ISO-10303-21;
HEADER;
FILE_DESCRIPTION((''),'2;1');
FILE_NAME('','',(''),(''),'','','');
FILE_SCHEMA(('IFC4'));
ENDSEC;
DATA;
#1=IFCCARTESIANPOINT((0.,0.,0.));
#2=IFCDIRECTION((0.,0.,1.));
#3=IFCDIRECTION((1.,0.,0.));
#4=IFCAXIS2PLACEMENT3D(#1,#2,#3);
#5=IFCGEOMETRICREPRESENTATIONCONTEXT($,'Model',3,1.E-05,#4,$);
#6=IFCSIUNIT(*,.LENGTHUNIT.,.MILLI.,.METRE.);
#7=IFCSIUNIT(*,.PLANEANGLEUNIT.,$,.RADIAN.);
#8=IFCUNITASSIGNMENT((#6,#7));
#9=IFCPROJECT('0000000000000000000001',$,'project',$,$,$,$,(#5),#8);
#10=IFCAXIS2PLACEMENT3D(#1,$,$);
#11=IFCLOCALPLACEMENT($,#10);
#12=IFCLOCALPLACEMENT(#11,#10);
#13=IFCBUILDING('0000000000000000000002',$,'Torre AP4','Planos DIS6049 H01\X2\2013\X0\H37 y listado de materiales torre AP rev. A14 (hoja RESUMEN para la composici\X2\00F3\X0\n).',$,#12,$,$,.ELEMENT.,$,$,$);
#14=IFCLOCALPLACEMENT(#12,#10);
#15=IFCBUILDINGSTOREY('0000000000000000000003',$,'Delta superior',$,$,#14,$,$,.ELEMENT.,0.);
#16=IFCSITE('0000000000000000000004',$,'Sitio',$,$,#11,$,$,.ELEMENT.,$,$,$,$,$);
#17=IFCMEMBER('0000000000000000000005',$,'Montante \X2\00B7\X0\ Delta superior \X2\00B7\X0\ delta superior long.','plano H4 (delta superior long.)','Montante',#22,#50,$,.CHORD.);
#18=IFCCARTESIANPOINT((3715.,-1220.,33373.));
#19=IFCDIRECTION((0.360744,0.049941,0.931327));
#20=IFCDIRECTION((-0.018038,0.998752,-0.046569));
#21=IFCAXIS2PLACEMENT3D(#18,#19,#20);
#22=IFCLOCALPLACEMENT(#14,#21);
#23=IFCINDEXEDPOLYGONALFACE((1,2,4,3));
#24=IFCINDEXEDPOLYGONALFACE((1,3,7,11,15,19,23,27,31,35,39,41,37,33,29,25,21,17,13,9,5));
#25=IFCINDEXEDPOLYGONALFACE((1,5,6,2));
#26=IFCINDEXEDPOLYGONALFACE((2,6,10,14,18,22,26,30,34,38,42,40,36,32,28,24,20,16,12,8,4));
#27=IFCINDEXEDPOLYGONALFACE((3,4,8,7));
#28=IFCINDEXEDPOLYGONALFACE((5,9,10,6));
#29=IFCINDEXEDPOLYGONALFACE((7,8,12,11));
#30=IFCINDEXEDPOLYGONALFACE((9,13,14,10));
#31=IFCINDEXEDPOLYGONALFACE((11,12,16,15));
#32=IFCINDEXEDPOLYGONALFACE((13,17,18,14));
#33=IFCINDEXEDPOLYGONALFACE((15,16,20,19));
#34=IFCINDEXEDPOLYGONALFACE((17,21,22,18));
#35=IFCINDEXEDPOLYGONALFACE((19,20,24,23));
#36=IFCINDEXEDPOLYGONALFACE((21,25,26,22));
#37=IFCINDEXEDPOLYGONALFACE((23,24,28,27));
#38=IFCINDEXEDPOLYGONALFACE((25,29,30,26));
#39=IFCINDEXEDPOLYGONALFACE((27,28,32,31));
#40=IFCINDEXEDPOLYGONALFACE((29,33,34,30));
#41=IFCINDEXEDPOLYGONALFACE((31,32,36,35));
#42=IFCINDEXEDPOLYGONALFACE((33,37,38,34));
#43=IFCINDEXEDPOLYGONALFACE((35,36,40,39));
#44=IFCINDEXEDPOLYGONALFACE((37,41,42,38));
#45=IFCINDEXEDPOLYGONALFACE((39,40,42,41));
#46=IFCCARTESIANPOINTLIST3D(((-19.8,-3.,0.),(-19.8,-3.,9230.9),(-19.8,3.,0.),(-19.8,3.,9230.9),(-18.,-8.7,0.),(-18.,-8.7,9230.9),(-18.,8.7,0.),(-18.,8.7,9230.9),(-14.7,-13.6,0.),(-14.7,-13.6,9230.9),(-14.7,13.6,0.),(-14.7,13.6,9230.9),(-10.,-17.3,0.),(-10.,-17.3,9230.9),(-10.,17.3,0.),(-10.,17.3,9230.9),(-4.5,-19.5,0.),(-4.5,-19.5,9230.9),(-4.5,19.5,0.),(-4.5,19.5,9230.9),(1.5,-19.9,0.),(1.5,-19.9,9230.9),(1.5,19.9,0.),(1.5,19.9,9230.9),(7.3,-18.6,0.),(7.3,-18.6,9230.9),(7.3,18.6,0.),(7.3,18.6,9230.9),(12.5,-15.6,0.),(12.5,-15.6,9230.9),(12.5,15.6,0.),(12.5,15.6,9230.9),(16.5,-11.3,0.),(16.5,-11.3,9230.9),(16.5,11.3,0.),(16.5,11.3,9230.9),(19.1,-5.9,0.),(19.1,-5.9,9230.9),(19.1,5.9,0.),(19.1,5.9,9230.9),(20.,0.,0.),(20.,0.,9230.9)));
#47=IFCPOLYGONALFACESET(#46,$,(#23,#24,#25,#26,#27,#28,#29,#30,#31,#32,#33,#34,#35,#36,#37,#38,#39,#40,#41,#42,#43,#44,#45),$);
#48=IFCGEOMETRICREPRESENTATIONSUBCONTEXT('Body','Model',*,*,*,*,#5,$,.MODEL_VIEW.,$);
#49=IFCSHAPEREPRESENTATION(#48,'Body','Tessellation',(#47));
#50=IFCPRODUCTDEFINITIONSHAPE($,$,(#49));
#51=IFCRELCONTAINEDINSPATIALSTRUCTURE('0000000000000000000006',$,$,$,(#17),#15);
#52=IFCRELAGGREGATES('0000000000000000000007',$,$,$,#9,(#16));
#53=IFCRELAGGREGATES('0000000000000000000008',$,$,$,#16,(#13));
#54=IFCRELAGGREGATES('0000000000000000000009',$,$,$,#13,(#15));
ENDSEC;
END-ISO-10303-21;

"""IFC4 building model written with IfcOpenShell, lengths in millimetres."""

from ifc_helpers import new_model, si_unit, frame, origin, origin_with_axes, place, context, subcontext, project, spatial, circle, extrude, element, save


model = new_model("IFC4")

# Units and contexts
model_context = context("Model", 3, precision=1e-05, world=origin_with_axes())
body_context = subcontext(model_context, "Body", "Model", "MODEL_VIEW")
ifc_project = project(units=[si_unit("LENGTHUNIT", "METRE", prefix="MILLI"), si_unit("PLANEANGLEUNIT", "RADIAN")], contexts=[model_context])

# Site, building, storey
site_placement = place(None, origin())
site = spatial("IfcSite", under=ifc_project, at=site_placement, Name="Sitio", CompositionType="ELEMENT")
building_placement = place(site_placement, origin())
building = spatial("IfcBuilding", under=site, at=building_placement, Name="Torre AP4", Description="Planos DIS6049 H01–H37 y listado de materiales torre AP rev. A14 (hoja RESUMEN para la composición).", CompositionType="ELEMENT")
storey_placement = place(building_placement, origin())
storey = spatial("IfcBuildingStorey", under=building, at=storey_placement, Name="Delta superior", CompositionType="ELEMENT", Elevation=0.0)

# Member
for number, where, z_axis, x_axis, name in (
    (1, (3715.0, -1220.0, 33373.0), (0.360744, 0.049941, 0.931327), (-0.018038, 0.998752, -0.046569), "Montante · Delta superior · delta superior long."),
):
    element("IfcMember", number, at=place(storey_placement, frame(where, z_axis=z_axis, x_axis=x_axis)), inside=storey, Name=name, Description="plano H4 (delta superior long.)", ObjectType="Montante", PredefinedType="CHORD", context=body_context, shape_type="SweptSolid", body=[
        extrude(circle(Radius=20.0), None, (0.0, 0.0, 1.0), 9230.9),
    ])

save(model, "model.ifc")
